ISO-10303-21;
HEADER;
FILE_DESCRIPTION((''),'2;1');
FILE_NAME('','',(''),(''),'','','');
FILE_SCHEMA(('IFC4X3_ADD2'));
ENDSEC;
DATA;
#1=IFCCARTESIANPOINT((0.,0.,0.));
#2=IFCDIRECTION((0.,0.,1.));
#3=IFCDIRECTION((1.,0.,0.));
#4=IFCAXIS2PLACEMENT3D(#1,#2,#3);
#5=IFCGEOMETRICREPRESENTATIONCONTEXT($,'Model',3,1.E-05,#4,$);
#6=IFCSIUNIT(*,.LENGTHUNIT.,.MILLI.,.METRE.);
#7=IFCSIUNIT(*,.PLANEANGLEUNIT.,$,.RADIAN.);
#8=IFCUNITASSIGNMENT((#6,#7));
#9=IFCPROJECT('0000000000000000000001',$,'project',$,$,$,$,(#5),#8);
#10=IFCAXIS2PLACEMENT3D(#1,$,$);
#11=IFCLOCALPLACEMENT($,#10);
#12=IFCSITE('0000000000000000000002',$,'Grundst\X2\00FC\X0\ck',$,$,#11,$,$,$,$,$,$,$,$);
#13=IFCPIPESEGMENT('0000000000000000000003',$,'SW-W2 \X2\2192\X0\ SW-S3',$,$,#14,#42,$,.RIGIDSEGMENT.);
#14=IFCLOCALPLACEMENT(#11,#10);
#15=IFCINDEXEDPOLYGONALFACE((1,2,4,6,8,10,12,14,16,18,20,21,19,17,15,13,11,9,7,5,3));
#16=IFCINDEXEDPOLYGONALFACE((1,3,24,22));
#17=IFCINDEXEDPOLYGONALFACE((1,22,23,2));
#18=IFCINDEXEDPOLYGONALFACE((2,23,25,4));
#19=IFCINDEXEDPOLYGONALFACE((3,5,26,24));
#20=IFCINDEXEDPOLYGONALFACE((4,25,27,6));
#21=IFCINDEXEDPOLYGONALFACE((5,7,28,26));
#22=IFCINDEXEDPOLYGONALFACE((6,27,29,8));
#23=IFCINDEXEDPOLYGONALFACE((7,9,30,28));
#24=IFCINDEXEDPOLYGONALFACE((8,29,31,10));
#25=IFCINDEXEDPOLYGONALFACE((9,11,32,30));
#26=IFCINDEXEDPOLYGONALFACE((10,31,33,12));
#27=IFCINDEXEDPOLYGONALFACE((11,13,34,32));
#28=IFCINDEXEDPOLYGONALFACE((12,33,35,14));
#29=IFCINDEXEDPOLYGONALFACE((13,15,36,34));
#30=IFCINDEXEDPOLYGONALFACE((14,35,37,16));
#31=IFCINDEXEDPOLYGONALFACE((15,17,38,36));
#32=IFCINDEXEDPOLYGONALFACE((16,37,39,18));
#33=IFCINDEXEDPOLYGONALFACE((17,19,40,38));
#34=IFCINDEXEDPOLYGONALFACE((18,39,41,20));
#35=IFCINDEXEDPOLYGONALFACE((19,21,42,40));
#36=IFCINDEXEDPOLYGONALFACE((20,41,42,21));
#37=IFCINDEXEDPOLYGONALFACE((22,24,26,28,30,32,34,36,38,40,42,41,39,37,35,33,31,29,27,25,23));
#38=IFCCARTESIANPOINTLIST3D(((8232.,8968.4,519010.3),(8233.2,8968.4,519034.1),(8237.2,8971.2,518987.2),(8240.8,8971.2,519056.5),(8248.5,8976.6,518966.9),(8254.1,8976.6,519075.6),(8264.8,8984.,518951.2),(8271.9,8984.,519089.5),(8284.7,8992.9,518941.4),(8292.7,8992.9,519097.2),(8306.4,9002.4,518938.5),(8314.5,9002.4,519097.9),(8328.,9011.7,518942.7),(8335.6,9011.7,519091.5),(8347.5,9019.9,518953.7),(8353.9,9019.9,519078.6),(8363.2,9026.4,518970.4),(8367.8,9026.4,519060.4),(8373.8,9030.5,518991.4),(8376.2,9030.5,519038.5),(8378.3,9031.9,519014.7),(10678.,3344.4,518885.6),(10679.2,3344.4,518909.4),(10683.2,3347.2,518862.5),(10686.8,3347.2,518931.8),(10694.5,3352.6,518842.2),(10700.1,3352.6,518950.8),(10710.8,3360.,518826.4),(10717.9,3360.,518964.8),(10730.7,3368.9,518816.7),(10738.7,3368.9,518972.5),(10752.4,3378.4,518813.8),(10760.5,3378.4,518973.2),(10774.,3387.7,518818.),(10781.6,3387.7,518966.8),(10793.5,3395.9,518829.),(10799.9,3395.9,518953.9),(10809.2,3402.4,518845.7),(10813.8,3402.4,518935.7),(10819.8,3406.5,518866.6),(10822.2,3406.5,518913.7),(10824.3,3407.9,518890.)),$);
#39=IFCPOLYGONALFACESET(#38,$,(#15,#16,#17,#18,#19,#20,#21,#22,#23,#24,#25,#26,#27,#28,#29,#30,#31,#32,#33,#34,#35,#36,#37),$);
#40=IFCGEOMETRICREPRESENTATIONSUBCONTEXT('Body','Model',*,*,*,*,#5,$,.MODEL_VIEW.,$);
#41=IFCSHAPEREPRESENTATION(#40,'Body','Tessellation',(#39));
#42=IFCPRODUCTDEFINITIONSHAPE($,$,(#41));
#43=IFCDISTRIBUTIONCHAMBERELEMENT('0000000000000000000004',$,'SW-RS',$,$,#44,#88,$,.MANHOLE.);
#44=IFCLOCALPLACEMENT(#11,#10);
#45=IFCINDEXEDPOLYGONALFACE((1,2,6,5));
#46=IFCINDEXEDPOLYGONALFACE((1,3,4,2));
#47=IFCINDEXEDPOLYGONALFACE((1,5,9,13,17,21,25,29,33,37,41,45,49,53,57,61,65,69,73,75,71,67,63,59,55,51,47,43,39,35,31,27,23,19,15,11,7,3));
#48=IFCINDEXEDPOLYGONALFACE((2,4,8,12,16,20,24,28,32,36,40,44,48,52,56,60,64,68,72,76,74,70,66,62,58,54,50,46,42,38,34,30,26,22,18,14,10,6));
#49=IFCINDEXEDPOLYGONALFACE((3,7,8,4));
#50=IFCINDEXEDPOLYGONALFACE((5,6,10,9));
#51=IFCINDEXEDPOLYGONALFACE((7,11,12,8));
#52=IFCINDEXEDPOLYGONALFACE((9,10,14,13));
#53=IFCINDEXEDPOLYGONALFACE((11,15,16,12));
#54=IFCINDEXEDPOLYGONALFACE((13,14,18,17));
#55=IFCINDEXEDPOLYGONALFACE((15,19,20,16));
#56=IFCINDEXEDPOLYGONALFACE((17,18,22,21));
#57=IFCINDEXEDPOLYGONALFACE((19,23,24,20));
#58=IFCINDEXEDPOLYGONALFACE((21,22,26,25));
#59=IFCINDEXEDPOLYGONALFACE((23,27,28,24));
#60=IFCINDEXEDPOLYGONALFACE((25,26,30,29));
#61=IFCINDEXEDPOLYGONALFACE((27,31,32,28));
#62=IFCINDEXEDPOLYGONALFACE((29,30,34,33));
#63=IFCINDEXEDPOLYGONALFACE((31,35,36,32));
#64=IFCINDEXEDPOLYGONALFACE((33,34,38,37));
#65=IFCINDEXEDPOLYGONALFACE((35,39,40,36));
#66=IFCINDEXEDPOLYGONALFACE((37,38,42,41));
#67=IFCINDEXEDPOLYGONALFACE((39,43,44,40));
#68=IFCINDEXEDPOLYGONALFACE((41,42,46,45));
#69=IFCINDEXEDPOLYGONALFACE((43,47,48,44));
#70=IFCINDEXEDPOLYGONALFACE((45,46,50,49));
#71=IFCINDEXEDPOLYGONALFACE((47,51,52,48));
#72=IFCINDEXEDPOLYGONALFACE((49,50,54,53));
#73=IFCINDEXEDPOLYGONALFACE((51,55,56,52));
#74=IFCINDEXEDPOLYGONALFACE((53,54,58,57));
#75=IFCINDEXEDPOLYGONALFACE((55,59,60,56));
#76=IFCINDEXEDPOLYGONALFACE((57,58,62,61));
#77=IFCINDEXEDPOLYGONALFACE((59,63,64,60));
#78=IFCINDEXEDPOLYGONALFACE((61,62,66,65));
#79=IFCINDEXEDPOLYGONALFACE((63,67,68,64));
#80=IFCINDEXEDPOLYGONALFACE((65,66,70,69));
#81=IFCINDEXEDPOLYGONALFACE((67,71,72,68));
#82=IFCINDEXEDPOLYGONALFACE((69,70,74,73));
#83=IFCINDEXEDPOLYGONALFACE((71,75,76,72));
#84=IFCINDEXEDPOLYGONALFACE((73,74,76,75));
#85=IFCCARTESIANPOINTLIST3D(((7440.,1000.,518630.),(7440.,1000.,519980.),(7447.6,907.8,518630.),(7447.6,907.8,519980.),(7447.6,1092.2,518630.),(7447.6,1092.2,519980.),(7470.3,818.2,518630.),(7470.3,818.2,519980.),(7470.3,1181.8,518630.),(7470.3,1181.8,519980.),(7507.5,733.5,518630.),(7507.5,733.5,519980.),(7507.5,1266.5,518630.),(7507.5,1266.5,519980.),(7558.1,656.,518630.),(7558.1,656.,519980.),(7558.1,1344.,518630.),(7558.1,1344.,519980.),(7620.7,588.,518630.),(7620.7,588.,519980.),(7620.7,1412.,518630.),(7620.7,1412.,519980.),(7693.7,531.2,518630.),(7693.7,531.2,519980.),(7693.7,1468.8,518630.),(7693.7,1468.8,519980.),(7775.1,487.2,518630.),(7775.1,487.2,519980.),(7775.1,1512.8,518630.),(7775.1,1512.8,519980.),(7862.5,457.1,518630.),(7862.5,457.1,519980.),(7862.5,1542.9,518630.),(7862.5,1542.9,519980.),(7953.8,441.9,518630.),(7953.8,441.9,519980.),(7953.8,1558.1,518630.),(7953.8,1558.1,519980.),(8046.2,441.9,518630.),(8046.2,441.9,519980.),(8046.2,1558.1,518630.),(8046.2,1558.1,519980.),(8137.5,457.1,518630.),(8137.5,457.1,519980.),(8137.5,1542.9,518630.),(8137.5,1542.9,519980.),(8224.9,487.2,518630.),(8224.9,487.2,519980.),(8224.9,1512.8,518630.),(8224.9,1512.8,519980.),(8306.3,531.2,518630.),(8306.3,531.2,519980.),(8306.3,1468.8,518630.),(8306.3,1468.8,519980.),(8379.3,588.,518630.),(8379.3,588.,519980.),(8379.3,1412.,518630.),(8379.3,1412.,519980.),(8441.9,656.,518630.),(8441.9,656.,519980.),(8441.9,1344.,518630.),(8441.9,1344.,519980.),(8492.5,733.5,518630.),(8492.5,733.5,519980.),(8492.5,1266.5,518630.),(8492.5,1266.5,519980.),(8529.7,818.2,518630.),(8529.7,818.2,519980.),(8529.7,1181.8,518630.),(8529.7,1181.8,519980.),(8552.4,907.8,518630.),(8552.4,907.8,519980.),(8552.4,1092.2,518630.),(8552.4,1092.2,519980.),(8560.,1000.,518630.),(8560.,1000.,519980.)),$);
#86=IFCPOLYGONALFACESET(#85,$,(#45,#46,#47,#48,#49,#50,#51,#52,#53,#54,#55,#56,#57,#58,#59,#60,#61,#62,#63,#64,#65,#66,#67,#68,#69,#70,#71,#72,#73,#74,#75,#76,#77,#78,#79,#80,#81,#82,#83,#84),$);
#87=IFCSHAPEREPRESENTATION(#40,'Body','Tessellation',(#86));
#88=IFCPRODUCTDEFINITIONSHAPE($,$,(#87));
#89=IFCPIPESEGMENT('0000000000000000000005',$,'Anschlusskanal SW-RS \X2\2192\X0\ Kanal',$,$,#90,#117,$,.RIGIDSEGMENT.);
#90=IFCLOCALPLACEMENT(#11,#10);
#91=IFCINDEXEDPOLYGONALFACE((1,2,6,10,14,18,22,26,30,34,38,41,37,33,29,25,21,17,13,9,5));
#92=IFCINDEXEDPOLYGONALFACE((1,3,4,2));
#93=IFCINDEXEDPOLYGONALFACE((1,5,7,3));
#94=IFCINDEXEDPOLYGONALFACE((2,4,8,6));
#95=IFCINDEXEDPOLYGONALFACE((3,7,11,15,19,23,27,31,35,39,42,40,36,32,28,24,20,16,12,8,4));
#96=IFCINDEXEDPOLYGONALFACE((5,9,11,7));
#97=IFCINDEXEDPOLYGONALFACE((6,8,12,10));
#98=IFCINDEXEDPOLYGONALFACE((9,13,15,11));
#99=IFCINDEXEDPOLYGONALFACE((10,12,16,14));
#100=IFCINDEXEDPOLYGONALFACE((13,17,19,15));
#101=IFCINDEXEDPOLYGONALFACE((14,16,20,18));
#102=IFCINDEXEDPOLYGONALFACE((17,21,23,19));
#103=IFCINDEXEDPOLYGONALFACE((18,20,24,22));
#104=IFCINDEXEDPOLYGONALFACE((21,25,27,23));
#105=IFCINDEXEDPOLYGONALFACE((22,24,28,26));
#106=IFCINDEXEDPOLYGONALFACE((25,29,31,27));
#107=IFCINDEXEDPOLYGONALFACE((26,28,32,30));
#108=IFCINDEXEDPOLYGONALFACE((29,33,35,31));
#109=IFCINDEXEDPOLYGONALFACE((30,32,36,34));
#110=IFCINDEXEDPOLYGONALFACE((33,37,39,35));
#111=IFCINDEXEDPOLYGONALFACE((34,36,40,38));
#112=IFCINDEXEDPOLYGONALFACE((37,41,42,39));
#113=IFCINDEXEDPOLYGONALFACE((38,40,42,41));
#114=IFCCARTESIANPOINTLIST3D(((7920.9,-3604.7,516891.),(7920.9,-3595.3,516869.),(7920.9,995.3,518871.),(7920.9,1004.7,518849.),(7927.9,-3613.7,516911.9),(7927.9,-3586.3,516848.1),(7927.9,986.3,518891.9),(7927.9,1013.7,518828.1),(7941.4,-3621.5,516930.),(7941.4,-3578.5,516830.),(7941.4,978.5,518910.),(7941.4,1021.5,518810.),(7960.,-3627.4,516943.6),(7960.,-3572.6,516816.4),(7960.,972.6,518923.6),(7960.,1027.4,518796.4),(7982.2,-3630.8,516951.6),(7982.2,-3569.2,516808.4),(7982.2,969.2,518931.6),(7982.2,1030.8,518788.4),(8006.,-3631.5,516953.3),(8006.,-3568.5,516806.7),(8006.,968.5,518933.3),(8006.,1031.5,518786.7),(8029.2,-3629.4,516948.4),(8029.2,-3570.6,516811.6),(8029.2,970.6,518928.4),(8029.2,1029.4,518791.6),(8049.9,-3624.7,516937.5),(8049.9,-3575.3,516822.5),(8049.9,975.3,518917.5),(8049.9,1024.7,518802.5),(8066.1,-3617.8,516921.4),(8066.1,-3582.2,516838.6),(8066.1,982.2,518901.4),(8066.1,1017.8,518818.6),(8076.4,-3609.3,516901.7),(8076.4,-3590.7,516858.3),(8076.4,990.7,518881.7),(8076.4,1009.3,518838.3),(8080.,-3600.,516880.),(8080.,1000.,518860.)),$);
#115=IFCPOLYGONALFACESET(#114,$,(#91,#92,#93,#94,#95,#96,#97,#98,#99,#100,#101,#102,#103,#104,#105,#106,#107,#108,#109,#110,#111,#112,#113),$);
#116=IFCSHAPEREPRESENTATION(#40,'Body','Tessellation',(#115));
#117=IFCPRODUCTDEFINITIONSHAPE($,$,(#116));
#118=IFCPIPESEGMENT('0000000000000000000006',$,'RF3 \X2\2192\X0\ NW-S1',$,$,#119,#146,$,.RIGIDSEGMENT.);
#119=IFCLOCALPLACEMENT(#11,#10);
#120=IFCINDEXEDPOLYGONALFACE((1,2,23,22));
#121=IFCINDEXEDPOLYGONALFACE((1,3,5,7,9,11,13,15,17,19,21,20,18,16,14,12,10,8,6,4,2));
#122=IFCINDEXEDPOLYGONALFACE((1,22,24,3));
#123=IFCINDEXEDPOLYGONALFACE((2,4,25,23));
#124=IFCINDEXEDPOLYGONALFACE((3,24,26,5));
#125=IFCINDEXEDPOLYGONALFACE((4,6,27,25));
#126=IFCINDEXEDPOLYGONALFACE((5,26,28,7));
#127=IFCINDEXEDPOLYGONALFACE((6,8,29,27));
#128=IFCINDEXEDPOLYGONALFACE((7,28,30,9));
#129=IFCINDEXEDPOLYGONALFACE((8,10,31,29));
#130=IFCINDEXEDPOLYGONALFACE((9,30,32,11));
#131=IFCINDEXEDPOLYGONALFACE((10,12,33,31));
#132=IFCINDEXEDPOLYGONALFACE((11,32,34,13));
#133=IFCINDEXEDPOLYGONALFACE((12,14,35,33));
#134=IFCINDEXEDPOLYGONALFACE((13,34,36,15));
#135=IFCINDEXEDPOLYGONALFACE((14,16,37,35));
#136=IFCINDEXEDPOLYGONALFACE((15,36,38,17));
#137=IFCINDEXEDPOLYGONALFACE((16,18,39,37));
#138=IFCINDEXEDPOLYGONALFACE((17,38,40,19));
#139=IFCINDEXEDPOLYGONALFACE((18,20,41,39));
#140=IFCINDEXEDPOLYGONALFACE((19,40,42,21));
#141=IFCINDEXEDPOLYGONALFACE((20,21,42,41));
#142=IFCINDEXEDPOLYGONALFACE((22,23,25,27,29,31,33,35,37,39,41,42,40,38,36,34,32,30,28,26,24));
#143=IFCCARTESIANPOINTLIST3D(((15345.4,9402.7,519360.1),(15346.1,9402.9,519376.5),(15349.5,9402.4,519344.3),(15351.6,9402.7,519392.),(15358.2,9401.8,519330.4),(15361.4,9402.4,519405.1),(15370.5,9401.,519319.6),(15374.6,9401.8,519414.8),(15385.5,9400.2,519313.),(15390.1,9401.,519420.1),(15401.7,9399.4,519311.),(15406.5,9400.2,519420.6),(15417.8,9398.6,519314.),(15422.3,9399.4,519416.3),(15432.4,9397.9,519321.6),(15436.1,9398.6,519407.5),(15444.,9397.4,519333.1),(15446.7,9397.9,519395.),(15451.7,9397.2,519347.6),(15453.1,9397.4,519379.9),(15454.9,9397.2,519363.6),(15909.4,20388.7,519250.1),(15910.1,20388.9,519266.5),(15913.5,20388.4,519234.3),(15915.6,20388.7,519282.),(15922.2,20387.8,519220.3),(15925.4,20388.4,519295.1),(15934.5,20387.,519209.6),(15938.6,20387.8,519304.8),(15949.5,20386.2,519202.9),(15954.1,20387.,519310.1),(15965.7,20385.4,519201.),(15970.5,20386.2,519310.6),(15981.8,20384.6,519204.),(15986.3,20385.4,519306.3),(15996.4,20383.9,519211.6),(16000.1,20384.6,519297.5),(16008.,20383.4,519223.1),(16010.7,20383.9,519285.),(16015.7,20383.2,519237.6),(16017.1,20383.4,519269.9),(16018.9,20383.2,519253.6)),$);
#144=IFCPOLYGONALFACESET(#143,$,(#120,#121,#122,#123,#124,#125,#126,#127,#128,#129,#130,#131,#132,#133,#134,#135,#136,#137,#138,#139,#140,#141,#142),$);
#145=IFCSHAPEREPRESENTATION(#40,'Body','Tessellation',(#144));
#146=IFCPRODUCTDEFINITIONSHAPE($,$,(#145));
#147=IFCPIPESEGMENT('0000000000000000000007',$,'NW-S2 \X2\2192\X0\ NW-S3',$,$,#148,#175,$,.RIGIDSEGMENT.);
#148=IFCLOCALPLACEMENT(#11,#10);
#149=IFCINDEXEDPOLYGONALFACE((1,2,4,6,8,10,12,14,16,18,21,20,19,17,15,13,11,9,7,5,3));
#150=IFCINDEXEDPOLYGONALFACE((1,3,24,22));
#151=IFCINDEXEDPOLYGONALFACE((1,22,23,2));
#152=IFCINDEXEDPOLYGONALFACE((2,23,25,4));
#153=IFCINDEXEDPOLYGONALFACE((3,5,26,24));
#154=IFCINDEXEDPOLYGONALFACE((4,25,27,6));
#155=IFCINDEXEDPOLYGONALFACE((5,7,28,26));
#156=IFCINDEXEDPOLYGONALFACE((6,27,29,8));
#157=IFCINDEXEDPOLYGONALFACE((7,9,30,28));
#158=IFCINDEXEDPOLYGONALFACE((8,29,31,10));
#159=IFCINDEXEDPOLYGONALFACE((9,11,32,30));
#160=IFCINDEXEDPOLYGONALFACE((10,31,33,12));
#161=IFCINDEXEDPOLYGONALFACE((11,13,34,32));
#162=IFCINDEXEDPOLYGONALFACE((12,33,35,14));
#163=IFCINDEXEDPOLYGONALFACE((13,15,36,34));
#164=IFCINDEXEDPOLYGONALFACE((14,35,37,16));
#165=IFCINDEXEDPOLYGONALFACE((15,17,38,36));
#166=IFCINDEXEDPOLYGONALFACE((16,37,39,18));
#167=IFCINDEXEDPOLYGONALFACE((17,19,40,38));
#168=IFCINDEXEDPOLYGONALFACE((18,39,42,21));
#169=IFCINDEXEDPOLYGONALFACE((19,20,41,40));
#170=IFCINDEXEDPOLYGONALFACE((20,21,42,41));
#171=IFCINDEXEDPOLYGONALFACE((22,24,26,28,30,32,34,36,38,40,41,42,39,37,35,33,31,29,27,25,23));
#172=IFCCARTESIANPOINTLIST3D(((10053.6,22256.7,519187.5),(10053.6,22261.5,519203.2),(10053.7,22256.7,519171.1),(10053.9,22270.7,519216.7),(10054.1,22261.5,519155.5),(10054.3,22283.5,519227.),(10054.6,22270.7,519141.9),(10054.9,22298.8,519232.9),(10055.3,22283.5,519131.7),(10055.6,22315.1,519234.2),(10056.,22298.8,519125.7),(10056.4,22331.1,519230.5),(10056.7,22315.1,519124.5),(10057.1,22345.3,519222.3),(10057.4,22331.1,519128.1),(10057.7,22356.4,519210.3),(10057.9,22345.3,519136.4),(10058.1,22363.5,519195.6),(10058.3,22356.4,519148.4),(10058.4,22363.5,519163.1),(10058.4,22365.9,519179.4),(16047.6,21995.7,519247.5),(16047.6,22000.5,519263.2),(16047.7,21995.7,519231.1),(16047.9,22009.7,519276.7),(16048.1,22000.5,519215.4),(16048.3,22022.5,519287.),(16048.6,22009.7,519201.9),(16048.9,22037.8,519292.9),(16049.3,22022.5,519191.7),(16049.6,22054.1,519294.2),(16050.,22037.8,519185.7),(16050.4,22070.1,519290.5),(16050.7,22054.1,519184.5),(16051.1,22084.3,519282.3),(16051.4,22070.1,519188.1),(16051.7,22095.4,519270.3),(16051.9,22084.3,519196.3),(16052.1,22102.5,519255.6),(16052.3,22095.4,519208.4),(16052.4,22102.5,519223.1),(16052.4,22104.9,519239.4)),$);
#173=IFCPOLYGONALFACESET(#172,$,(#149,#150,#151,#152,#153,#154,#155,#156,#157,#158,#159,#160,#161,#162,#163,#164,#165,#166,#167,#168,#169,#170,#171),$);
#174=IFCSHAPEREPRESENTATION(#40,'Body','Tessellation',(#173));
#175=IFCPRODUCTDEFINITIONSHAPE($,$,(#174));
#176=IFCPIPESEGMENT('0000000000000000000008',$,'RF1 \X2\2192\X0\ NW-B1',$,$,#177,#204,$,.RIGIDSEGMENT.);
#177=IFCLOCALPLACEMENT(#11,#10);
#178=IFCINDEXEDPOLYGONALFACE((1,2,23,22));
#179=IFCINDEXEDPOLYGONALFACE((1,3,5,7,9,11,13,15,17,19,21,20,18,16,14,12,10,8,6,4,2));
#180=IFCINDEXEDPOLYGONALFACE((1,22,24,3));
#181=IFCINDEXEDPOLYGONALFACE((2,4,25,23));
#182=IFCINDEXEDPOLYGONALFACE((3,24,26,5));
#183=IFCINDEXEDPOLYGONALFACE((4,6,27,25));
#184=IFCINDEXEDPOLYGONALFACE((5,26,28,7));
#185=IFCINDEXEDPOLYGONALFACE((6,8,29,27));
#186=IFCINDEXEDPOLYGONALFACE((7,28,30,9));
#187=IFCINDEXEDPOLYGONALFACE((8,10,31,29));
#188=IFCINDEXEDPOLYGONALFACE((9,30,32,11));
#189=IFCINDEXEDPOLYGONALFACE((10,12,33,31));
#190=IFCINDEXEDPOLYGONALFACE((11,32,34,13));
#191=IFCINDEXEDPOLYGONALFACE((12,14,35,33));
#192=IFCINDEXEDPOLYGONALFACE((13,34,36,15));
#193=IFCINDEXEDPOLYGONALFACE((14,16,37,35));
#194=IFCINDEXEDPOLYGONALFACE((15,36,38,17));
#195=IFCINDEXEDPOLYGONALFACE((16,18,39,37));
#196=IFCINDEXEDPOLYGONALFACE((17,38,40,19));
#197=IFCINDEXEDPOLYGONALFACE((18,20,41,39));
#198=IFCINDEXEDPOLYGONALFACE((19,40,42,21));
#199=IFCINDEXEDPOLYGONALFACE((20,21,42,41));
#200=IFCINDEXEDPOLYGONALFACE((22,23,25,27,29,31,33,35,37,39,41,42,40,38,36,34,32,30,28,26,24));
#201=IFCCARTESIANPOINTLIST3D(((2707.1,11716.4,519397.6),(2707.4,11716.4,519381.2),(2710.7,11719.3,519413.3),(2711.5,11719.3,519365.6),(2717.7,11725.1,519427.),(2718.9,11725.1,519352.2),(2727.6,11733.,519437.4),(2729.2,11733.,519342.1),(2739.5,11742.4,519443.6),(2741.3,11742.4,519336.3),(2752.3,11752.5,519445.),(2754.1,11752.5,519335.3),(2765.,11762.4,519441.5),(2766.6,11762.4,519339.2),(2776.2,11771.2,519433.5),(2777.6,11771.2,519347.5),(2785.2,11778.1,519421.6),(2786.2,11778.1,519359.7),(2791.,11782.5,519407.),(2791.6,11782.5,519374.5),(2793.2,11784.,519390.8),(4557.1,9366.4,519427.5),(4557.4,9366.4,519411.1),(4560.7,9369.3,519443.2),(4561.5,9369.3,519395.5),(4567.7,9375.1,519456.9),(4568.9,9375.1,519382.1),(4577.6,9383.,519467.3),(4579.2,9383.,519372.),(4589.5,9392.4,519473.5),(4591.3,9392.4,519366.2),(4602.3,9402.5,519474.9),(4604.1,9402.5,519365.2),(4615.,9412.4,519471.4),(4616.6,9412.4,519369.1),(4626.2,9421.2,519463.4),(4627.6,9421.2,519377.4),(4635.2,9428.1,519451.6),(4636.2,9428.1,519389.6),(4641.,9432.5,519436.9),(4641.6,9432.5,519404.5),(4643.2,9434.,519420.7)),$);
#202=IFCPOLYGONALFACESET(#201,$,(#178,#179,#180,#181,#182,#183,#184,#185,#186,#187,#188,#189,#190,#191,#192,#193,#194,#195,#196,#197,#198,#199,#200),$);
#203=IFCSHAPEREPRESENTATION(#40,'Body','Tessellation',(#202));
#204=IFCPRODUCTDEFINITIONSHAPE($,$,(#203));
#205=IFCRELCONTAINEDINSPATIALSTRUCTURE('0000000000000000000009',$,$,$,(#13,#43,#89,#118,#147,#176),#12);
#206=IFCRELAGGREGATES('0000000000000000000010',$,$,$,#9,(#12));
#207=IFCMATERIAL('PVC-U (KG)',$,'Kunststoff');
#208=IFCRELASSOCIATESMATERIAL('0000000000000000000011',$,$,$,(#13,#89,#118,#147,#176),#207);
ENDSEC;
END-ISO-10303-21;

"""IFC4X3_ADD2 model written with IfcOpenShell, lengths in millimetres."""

from ifc_helpers import new_model, si_unit, frame, origin, origin_with_axes, place, context, subcontext, project, spatial, circle, extrude, material, element, save


model = new_model("IFC4X3_ADD2")

# Units and contexts
model_context = context("Model", 3, precision=1e-05, world=origin_with_axes())
body_context = subcontext(model_context, "Body", "Model", "MODEL_VIEW")
ifc_project = project(units=[si_unit("LENGTHUNIT", "METRE", prefix="MILLI"), si_unit("PLANEANGLEUNIT", "RADIAN")], contexts=[model_context])

# Site
site_placement = place(None, origin())
site = spatial("IfcSite", under=ifc_project, at=site_placement, Name="Grundstück")

# Pipe segment
ifc_material = material(Name="PVC-U (KG)", Category="Kunststoff")
pipe_segment_1_placement = place(site_placement, frame((8305.0, 9000.0, 518938.5)))
element("IfcPipeSegment", 1, at=pipe_segment_1_placement, inside=site, material=ifc_material, Name="SW-W2 → SW-S3", PredefinedType="RIGIDSEGMENT", context=body_context, shape_type="SweptSolid", body=[
    extrude(circle(Radius=80.0), frame((0.0, 0.0, 80.0), z_axis=(0.398751, -0.916834, -0.02033), x_axis=(0.0, 1.0, 0.0)), (0.0, 0.0, 1.0), 6134.2),
])

# Distribution chamber element
distribution_chamber_element_1_placement = place(site_placement, frame((8000.0, 1000.0, 518780.0)))
element("IfcDistributionChamberElement", 2, at=distribution_chamber_element_1_placement, inside=site, Name="SW-RS", PredefinedType="MANHOLE", context=body_context, shape_type="SweptSolid", body=[
    extrude(circle(Radius=560.0), frame((0.0, 0.0, -150.0)), (0.0, 0.0, 1.0), 1350.0),
])

# Pipe segments
pipe_segment_2_placement = place(site_placement, frame((8000.0, 1000.0, 518780.0)))
element("IfcPipeSegment", 3, at=pipe_segment_2_placement, inside=site, material=ifc_material, Name="Anschlusskanal SW-RS → Kanal", PredefinedType="RIGIDSEGMENT", context=body_context, shape_type="SweptSolid", body=[
    extrude(circle(Radius=80.0), frame((0.0, 0.0, 80.0), z_axis=(0.0, -0.918524, -0.395365), x_axis=(1.0, 0.0, 0.0)), (0.0, 0.0, 1.0), 5008.0),
])
pipe_segment_3_placement = place(site_placement, frame((15400.0, 9400.0, 519311.0)))
element("IfcPipeSegment", 4, at=pipe_segment_3_placement, inside=site, material=ifc_material, Name="RF3 → NW-S1", PredefinedType="RIGIDSEGMENT", context=body_context, shape_type="SweptSolid", body=[
    extrude(circle(Radius=55.0), frame((0.0, 0.0, 55.0), z_axis=(0.051268, 0.998635, -0.01), x_axis=(0.0, 1.0, 0.0)), (0.0, 0.0, 1.0), 11001.0),
])
pipe_segment_4_placement = place(site_placement, frame((16050.0, 22050.0, 519184.3)))
element("IfcPipeSegment", 5, at=pipe_segment_4_placement, inside=site, material=ifc_material, Name="NW-S2 → NW-S3", PredefinedType="RIGIDSEGMENT", context=body_context, shape_type="SweptSolid", body=[
    extrude(circle(Radius=55.0), frame((0.0, 0.0, 55.0), z_axis=(-0.999003, 0.0435, -0.01), x_axis=(0.0, 1.0, 0.0)), (0.0, 0.0, 1.0), 6000.0),
])
pipe_segment_5_placement = place(site_placement, frame((4600.0, 9400.0, 519365.0)))
element("IfcPipeSegment", 6, at=pipe_segment_5_placement, inside=site, material=ifc_material, Name="RF1 → NW-B1", PredefinedType="RIGIDSEGMENT", context=body_context, shape_type="SweptSolid", body=[
    extrude(circle(Radius=55.0), frame((0.0, 0.0, 55.0), z_axis=(-0.618529, 0.785699, -0.01), x_axis=(0.0, 1.0, 0.0)), (0.0, 0.0, 1.0), 2991.0),
])

save(model, "model.ifc")
